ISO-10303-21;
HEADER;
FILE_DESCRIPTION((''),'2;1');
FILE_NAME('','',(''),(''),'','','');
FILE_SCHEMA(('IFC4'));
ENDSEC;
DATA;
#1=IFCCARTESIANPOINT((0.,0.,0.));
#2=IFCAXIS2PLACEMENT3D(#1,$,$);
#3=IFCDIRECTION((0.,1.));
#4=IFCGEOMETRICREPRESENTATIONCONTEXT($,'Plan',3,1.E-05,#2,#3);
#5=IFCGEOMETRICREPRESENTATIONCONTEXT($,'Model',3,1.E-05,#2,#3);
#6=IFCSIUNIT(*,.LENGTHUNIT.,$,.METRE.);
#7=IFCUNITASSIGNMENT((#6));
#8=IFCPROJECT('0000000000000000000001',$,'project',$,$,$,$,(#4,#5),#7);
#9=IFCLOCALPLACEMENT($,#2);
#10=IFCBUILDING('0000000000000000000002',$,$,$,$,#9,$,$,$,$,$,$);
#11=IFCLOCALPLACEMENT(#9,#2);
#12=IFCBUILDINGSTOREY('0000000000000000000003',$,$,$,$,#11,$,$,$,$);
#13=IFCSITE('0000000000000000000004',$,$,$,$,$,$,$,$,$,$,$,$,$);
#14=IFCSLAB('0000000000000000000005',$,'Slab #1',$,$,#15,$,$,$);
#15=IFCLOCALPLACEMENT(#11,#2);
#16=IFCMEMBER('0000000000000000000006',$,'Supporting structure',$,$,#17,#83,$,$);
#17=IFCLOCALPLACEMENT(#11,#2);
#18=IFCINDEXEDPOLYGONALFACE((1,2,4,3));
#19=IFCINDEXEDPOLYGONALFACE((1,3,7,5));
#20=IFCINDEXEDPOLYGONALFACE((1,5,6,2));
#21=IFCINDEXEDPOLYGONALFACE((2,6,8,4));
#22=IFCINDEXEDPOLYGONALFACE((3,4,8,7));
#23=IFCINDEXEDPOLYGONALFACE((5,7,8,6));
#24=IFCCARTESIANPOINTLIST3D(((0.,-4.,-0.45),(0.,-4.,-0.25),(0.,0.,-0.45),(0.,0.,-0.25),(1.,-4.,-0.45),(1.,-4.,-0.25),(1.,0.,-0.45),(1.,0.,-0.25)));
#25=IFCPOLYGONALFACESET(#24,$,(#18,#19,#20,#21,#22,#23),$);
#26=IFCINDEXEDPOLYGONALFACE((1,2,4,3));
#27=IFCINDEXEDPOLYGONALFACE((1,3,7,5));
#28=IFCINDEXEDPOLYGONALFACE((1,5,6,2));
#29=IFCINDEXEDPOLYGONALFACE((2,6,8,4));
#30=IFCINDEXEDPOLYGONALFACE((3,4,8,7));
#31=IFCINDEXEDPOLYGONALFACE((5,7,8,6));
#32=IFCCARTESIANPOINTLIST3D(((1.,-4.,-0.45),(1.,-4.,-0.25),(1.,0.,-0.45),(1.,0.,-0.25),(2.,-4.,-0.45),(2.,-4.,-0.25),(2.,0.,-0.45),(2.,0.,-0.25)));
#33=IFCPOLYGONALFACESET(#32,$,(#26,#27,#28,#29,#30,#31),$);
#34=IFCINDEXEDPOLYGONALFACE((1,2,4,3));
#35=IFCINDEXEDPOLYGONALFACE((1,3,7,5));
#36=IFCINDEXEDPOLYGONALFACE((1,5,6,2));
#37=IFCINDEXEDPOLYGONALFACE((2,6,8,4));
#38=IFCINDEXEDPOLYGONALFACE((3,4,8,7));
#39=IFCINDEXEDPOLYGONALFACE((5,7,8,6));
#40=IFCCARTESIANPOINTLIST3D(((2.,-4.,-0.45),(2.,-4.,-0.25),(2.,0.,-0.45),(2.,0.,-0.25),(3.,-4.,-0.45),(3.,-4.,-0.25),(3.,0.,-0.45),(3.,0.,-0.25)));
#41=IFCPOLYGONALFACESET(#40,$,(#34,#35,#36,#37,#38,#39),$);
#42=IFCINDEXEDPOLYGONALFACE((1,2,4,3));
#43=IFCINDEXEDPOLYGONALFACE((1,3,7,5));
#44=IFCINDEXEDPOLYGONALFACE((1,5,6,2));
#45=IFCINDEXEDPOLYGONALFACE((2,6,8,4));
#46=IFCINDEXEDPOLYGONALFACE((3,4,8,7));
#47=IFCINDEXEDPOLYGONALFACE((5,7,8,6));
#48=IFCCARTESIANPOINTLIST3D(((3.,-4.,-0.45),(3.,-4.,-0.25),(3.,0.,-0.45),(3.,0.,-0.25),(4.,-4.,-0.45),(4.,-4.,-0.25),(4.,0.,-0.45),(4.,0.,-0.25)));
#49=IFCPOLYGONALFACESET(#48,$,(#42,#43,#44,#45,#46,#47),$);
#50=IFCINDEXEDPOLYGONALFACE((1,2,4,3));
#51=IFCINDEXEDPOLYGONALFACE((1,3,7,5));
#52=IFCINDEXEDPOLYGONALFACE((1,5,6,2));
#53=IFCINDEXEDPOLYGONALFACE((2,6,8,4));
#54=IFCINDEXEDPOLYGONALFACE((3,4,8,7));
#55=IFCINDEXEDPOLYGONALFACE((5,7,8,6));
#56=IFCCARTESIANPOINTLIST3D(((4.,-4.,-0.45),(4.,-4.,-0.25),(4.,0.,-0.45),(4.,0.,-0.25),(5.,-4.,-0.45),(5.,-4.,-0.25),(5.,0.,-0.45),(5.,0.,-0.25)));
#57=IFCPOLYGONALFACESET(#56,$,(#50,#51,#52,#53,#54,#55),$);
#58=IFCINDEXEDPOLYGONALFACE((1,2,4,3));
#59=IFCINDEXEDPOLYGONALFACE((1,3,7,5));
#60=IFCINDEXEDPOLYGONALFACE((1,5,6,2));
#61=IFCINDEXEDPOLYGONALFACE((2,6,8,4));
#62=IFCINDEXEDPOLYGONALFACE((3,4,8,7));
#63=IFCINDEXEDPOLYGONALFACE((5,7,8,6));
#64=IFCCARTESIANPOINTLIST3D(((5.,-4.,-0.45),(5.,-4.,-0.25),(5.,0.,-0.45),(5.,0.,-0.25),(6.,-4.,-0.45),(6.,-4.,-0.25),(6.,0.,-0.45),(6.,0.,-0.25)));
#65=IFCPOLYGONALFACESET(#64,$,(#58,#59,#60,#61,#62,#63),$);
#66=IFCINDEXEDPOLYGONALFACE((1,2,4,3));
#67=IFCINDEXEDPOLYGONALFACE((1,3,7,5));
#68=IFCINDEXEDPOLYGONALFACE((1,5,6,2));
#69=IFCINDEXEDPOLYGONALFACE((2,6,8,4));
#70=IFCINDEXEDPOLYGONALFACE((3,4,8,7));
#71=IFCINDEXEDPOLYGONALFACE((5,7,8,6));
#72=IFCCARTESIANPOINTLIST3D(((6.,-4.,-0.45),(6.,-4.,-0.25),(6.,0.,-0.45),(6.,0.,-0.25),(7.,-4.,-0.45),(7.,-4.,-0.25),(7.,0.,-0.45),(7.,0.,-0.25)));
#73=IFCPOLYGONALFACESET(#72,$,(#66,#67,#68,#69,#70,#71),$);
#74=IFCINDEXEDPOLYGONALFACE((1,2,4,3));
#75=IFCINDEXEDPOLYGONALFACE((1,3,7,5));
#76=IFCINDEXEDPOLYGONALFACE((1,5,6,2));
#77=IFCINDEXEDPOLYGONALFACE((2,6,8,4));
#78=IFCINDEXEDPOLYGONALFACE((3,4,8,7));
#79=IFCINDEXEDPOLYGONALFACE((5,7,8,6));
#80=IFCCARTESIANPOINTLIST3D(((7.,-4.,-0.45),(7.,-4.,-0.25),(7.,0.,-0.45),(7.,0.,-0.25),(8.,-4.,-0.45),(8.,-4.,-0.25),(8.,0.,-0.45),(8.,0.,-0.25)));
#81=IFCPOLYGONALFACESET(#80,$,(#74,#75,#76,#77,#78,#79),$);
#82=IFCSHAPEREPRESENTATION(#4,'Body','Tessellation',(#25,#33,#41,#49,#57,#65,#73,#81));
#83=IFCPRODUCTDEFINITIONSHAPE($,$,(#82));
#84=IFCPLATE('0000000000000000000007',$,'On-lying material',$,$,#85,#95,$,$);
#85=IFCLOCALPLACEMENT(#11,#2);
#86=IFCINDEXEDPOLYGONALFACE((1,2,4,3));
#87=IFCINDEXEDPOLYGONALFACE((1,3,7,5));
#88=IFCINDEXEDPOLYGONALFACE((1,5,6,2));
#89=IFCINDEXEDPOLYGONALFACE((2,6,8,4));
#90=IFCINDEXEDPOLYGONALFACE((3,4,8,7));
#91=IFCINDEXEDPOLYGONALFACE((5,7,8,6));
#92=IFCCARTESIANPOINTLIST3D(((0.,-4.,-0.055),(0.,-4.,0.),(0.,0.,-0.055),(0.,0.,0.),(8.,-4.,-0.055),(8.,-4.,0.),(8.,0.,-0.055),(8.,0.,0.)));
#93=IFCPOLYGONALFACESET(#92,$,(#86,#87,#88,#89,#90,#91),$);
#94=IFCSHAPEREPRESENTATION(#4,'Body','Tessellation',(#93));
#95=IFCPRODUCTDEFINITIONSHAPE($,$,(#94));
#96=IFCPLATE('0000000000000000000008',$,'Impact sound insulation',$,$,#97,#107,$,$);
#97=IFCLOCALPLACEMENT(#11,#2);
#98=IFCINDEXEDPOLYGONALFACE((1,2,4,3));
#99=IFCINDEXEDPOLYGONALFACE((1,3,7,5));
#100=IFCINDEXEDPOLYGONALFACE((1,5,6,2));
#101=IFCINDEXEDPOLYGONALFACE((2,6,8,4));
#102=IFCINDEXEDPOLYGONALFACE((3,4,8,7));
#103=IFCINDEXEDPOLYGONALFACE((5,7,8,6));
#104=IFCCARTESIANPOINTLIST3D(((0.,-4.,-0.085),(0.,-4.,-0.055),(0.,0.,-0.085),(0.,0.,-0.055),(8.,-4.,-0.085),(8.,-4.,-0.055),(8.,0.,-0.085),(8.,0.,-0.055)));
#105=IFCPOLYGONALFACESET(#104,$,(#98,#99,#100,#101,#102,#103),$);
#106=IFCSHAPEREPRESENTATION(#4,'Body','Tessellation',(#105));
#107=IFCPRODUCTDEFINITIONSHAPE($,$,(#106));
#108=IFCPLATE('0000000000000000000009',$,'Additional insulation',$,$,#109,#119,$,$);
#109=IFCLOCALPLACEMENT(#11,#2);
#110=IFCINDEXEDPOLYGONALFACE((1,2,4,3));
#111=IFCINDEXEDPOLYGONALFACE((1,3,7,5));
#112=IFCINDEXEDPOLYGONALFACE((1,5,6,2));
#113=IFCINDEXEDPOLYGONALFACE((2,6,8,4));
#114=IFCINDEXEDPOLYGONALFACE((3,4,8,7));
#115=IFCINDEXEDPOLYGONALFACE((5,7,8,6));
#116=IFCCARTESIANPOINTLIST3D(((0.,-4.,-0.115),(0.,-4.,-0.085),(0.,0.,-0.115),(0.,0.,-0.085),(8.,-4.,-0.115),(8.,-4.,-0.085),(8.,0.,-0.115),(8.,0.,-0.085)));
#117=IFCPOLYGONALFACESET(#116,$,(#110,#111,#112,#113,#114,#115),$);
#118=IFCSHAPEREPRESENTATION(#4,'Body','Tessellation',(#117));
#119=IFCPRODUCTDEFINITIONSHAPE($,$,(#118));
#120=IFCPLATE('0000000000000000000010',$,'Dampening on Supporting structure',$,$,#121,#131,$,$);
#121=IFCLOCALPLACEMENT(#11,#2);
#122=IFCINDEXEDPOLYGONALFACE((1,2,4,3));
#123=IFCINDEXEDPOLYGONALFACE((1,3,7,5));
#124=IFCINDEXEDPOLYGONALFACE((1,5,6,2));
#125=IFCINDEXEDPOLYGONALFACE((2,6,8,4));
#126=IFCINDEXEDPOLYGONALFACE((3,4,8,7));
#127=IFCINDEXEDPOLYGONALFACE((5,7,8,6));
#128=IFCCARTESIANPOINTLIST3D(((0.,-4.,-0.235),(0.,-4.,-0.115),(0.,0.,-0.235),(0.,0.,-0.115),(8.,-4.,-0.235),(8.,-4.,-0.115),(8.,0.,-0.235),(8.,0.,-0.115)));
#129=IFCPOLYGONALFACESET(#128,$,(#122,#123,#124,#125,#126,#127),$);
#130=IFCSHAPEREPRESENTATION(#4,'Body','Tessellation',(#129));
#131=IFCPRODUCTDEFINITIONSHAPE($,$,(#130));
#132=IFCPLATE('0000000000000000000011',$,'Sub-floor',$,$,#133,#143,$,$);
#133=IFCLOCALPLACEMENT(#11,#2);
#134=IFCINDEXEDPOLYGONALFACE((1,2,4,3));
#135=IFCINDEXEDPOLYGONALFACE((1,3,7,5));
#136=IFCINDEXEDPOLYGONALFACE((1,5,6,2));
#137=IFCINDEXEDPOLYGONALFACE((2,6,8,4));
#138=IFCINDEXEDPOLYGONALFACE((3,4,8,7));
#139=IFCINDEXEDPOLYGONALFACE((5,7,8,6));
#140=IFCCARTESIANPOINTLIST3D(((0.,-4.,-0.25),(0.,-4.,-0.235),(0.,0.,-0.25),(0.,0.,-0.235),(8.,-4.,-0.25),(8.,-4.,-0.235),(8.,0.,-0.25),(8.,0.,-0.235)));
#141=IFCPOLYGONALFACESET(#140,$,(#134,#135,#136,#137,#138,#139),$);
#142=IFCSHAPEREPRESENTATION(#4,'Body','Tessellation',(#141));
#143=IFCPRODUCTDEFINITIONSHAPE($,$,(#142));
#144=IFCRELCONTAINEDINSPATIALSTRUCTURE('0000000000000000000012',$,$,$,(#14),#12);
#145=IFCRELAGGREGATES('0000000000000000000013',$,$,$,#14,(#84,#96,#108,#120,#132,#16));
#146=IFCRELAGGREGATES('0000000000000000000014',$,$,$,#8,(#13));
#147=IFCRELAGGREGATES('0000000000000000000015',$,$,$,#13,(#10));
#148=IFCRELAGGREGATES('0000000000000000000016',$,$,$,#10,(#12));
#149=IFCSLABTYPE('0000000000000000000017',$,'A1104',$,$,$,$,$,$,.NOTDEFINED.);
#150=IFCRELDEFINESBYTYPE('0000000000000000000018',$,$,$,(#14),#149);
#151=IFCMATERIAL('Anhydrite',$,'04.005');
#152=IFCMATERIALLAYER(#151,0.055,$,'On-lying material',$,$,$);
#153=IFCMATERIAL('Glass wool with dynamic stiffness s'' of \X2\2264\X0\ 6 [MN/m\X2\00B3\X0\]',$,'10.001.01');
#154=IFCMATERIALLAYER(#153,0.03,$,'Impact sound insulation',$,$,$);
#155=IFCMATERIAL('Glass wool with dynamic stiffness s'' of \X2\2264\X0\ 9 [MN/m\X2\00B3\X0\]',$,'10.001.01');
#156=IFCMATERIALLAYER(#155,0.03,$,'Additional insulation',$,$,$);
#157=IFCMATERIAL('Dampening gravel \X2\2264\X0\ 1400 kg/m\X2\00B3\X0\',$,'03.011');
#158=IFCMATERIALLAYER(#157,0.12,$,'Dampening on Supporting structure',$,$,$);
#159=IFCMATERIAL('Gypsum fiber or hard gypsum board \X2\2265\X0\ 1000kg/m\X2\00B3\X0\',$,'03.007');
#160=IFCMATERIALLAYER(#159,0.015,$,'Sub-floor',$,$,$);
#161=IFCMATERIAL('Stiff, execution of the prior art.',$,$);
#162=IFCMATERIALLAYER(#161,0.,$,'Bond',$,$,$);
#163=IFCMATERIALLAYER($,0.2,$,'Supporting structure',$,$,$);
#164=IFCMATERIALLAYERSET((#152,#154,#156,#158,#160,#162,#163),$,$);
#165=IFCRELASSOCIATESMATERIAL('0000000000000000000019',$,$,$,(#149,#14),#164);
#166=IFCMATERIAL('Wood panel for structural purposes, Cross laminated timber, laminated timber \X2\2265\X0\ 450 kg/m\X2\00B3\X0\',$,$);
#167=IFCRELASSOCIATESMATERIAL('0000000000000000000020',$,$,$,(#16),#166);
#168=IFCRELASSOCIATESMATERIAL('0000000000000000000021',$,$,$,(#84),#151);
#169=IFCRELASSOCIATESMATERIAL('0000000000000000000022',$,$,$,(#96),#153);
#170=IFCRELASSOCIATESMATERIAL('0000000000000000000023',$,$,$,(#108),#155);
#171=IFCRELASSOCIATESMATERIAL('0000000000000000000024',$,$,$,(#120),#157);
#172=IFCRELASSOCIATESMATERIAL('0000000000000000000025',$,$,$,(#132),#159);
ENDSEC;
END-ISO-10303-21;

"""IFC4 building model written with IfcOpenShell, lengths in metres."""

from ifc_helpers import new_model, si_unit, direction, frame, frame_2d, origin, origin_with_axes, place, context, project, spatial, rectangle, extrude, material, layer, layer_set, type_object, element, aggregate, save


model = new_model("IFC4")

# Units and contexts
plan_context = context("Plan", 3, precision=1e-05, world=origin(), true_north=direction((0.0, 1.0)))
model_context = context("Model", 3, precision=1e-05, world=origin(), true_north=direction((0.0, 1.0)))
ifc_project = project(units=[si_unit("LENGTHUNIT", "METRE")], contexts=[plan_context, model_context])

# Site, building, storey
site = spatial("IfcSite", under=ifc_project)
building_placement = place(None, origin())
building = spatial("IfcBuilding", under=site, at=building_placement)
storey_placement = place(building_placement, origin())
storey = spatial("IfcBuildingStorey", under=building, at=storey_placement)

# Slab, member, plates
ifc_material_1 = material(Name="Anhydrite", Category="04.005")
ifc_layer_1 = layer(ifc_material_1, 0.055, Name="On-lying material")
ifc_material_2 = material(Name="Glass wool with dynamic stiffness s' of ≤ 6 [MN/m³]", Category="10.001.01")
ifc_layer_2 = layer(ifc_material_2, 0.03, Name="Impact sound insulation")
ifc_material_3 = material(Name="Glass wool with dynamic stiffness s' of ≤ 9 [MN/m³]", Category="10.001.01")
ifc_layer_3 = layer(ifc_material_3, 0.03, Name="Additional insulation")
ifc_material_4 = material(Name="Dampening gravel ≤ 1400 kg/m³", Category="03.011")
ifc_layer_4 = layer(ifc_material_4, 0.12, Name="Dampening on Supporting structure")
ifc_material_5 = material(Name="Gypsum fiber or hard gypsum board ≥ 1000kg/m³", Category="03.007")
ifc_layer_5 = layer(ifc_material_5, 0.015, Name="Sub-floor")
ifc_material_6 = material(Name="Stiff, execution of the prior art.")
ifc_layer_6 = layer(ifc_material_6, 0.0, Name="Bond")
ifc_layer_7 = layer(None, 0.2, Name="Supporting structure")
ifc_layer_set = layer_set([ifc_layer_1, ifc_layer_2, ifc_layer_3, ifc_layer_4, ifc_layer_5, ifc_layer_6, ifc_layer_7])
slab_type = type_object("IfcSlabType", Name="A1104", PredefinedType="NOTDEFINED", material=ifc_layer_set)
slab_placement = place(None, frame((0.0, 0.0, 0.0), z_axis=(0.0, 0.0, -1.0), x_axis=(1.0, 0.0, 0.0)))
slab = element("IfcSlab", 1, at=slab_placement, inside=storey, type_object=slab_type, material=ifc_layer_set, Name="Slab #1")
ifc_material_7 = material(Name="Wood panel for structural purposes, Cross laminated timber, laminated timber ≥ 450 kg/m³")
member_placement = place(slab_placement, origin())
member = element("IfcMember", 2, at=member_placement, material=ifc_material_7, Name="Supporting structure", context=plan_context, shape_type="SweptSolid", body=[
    extrude(rectangle(XDim=1.0, YDim=0.2, at=frame_2d((0.5, 0.1), x_axis=(1.0, 0.0))), frame((0.0, 4.0, 0.25), z_axis=(0.0, -1.0, 0.0), x_axis=(1.0, 0.0, 0.0)), (0.0, 0.0, 1.0), 4.0),
    extrude(rectangle(XDim=1.0, YDim=0.2, at=frame_2d((0.5, 0.1), x_axis=(1.0, 0.0))), frame((1.0, 4.0, 0.25), z_axis=(0.0, -1.0, 0.0), x_axis=(1.0, 0.0, 0.0)), (0.0, 0.0, 1.0), 4.0),
    extrude(rectangle(XDim=1.0, YDim=0.2, at=frame_2d((0.5, 0.1), x_axis=(1.0, 0.0))), frame((2.0, 4.0, 0.25), z_axis=(0.0, -1.0, 0.0), x_axis=(1.0, 0.0, 0.0)), (0.0, 0.0, 1.0), 4.0),
    extrude(rectangle(XDim=1.0, YDim=0.2, at=frame_2d((0.5, 0.1), x_axis=(1.0, 0.0))), frame((3.0, 4.0, 0.25), z_axis=(0.0, -1.0, 0.0), x_axis=(1.0, 0.0, 0.0)), (0.0, 0.0, 1.0), 4.0),
    extrude(rectangle(XDim=1.0, YDim=0.2, at=frame_2d((0.5, 0.1), x_axis=(1.0, 0.0))), frame((4.0, 4.0, 0.25), z_axis=(0.0, -1.0, 0.0), x_axis=(1.0, 0.0, 0.0)), (0.0, 0.0, 1.0), 4.0),
    extrude(rectangle(XDim=1.0, YDim=0.2, at=frame_2d((0.5, 0.1), x_axis=(1.0, 0.0))), frame((5.0, 4.0, 0.25), z_axis=(0.0, -1.0, 0.0), x_axis=(1.0, 0.0, 0.0)), (0.0, 0.0, 1.0), 4.0),
    extrude(rectangle(XDim=1.0, YDim=0.2, at=frame_2d((0.5, 0.1), x_axis=(1.0, 0.0))), frame((6.0, 4.0, 0.25), z_axis=(0.0, -1.0, 0.0), x_axis=(1.0, 0.0, 0.0)), (0.0, 0.0, 1.0), 4.0),
    extrude(rectangle(XDim=1.0, YDim=0.2, at=frame_2d((0.5, 0.1), x_axis=(1.0, 0.0))), frame((7.0, 4.0, 0.25), z_axis=(0.0, -1.0, 0.0), x_axis=(1.0, 0.0, 0.0)), (0.0, 0.0, 1.0), 4.0),
])
plate_1_placement = place(slab_placement, origin())
plate_1 = element("IfcPlate", 3, at=plate_1_placement, material=ifc_material_1, Name="On-lying material", context=plan_context, shape_type="SweptSolid", body=[
    extrude(rectangle(XDim=8.0, YDim=4.0, at=frame_2d((4.0, 2.0), x_axis=(1.0, 0.0))), origin_with_axes(), (0.0, 0.0, 1.0), 0.055),
])
plate_2_placement = place(slab_placement, origin())
plate_2 = element("IfcPlate", 4, at=plate_2_placement, material=ifc_material_2, Name="Impact sound insulation", context=plan_context, shape_type="SweptSolid", body=[
    extrude(rectangle(XDim=8.0, YDim=4.0, at=frame_2d((4.0, 2.0), x_axis=(1.0, 0.0))), frame((0.0, 0.0, 0.055), z_axis=(0.0, 0.0, 1.0), x_axis=(1.0, 0.0, 0.0)), (0.0, 0.0, 1.0), 0.03),
])
plate_3_placement = place(slab_placement, origin())
plate_3 = element("IfcPlate", 5, at=plate_3_placement, material=ifc_material_3, Name="Additional insulation", context=plan_context, shape_type="SweptSolid", body=[
    extrude(rectangle(XDim=8.0, YDim=4.0, at=frame_2d((4.0, 2.0), x_axis=(1.0, 0.0))), frame((0.0, 0.0, 0.085), z_axis=(0.0, 0.0, 1.0), x_axis=(1.0, 0.0, 0.0)), (0.0, 0.0, 1.0), 0.03),
])
plate_4_placement = place(slab_placement, origin())
plate_4 = element("IfcPlate", 6, at=plate_4_placement, material=ifc_material_4, Name="Dampening on Supporting structure", context=plan_context, shape_type="SweptSolid", body=[
    extrude(rectangle(XDim=8.0, YDim=4.0, at=frame_2d((4.0, 2.0), x_axis=(1.0, 0.0))), frame((0.0, 0.0, 0.115), z_axis=(0.0, 0.0, 1.0), x_axis=(1.0, 0.0, 0.0)), (0.0, 0.0, 1.0), 0.12),
])
plate_5_placement = place(slab_placement, origin())
plate_5 = element("IfcPlate", 7, at=plate_5_placement, material=ifc_material_5, Name="Sub-floor", context=plan_context, shape_type="SweptSolid", body=[
    extrude(rectangle(XDim=8.0, YDim=4.0, at=frame_2d((4.0, 2.0), x_axis=(1.0, 0.0))), frame((0.0, 0.0, 0.235), z_axis=(0.0, 0.0, 1.0), x_axis=(1.0, 0.0, 0.0)), (0.0, 0.0, 1.0), 0.015),
])
aggregate(slab, [plate_1, plate_2, plate_3, plate_4, plate_5, member])

save(model, "model.ifc")
